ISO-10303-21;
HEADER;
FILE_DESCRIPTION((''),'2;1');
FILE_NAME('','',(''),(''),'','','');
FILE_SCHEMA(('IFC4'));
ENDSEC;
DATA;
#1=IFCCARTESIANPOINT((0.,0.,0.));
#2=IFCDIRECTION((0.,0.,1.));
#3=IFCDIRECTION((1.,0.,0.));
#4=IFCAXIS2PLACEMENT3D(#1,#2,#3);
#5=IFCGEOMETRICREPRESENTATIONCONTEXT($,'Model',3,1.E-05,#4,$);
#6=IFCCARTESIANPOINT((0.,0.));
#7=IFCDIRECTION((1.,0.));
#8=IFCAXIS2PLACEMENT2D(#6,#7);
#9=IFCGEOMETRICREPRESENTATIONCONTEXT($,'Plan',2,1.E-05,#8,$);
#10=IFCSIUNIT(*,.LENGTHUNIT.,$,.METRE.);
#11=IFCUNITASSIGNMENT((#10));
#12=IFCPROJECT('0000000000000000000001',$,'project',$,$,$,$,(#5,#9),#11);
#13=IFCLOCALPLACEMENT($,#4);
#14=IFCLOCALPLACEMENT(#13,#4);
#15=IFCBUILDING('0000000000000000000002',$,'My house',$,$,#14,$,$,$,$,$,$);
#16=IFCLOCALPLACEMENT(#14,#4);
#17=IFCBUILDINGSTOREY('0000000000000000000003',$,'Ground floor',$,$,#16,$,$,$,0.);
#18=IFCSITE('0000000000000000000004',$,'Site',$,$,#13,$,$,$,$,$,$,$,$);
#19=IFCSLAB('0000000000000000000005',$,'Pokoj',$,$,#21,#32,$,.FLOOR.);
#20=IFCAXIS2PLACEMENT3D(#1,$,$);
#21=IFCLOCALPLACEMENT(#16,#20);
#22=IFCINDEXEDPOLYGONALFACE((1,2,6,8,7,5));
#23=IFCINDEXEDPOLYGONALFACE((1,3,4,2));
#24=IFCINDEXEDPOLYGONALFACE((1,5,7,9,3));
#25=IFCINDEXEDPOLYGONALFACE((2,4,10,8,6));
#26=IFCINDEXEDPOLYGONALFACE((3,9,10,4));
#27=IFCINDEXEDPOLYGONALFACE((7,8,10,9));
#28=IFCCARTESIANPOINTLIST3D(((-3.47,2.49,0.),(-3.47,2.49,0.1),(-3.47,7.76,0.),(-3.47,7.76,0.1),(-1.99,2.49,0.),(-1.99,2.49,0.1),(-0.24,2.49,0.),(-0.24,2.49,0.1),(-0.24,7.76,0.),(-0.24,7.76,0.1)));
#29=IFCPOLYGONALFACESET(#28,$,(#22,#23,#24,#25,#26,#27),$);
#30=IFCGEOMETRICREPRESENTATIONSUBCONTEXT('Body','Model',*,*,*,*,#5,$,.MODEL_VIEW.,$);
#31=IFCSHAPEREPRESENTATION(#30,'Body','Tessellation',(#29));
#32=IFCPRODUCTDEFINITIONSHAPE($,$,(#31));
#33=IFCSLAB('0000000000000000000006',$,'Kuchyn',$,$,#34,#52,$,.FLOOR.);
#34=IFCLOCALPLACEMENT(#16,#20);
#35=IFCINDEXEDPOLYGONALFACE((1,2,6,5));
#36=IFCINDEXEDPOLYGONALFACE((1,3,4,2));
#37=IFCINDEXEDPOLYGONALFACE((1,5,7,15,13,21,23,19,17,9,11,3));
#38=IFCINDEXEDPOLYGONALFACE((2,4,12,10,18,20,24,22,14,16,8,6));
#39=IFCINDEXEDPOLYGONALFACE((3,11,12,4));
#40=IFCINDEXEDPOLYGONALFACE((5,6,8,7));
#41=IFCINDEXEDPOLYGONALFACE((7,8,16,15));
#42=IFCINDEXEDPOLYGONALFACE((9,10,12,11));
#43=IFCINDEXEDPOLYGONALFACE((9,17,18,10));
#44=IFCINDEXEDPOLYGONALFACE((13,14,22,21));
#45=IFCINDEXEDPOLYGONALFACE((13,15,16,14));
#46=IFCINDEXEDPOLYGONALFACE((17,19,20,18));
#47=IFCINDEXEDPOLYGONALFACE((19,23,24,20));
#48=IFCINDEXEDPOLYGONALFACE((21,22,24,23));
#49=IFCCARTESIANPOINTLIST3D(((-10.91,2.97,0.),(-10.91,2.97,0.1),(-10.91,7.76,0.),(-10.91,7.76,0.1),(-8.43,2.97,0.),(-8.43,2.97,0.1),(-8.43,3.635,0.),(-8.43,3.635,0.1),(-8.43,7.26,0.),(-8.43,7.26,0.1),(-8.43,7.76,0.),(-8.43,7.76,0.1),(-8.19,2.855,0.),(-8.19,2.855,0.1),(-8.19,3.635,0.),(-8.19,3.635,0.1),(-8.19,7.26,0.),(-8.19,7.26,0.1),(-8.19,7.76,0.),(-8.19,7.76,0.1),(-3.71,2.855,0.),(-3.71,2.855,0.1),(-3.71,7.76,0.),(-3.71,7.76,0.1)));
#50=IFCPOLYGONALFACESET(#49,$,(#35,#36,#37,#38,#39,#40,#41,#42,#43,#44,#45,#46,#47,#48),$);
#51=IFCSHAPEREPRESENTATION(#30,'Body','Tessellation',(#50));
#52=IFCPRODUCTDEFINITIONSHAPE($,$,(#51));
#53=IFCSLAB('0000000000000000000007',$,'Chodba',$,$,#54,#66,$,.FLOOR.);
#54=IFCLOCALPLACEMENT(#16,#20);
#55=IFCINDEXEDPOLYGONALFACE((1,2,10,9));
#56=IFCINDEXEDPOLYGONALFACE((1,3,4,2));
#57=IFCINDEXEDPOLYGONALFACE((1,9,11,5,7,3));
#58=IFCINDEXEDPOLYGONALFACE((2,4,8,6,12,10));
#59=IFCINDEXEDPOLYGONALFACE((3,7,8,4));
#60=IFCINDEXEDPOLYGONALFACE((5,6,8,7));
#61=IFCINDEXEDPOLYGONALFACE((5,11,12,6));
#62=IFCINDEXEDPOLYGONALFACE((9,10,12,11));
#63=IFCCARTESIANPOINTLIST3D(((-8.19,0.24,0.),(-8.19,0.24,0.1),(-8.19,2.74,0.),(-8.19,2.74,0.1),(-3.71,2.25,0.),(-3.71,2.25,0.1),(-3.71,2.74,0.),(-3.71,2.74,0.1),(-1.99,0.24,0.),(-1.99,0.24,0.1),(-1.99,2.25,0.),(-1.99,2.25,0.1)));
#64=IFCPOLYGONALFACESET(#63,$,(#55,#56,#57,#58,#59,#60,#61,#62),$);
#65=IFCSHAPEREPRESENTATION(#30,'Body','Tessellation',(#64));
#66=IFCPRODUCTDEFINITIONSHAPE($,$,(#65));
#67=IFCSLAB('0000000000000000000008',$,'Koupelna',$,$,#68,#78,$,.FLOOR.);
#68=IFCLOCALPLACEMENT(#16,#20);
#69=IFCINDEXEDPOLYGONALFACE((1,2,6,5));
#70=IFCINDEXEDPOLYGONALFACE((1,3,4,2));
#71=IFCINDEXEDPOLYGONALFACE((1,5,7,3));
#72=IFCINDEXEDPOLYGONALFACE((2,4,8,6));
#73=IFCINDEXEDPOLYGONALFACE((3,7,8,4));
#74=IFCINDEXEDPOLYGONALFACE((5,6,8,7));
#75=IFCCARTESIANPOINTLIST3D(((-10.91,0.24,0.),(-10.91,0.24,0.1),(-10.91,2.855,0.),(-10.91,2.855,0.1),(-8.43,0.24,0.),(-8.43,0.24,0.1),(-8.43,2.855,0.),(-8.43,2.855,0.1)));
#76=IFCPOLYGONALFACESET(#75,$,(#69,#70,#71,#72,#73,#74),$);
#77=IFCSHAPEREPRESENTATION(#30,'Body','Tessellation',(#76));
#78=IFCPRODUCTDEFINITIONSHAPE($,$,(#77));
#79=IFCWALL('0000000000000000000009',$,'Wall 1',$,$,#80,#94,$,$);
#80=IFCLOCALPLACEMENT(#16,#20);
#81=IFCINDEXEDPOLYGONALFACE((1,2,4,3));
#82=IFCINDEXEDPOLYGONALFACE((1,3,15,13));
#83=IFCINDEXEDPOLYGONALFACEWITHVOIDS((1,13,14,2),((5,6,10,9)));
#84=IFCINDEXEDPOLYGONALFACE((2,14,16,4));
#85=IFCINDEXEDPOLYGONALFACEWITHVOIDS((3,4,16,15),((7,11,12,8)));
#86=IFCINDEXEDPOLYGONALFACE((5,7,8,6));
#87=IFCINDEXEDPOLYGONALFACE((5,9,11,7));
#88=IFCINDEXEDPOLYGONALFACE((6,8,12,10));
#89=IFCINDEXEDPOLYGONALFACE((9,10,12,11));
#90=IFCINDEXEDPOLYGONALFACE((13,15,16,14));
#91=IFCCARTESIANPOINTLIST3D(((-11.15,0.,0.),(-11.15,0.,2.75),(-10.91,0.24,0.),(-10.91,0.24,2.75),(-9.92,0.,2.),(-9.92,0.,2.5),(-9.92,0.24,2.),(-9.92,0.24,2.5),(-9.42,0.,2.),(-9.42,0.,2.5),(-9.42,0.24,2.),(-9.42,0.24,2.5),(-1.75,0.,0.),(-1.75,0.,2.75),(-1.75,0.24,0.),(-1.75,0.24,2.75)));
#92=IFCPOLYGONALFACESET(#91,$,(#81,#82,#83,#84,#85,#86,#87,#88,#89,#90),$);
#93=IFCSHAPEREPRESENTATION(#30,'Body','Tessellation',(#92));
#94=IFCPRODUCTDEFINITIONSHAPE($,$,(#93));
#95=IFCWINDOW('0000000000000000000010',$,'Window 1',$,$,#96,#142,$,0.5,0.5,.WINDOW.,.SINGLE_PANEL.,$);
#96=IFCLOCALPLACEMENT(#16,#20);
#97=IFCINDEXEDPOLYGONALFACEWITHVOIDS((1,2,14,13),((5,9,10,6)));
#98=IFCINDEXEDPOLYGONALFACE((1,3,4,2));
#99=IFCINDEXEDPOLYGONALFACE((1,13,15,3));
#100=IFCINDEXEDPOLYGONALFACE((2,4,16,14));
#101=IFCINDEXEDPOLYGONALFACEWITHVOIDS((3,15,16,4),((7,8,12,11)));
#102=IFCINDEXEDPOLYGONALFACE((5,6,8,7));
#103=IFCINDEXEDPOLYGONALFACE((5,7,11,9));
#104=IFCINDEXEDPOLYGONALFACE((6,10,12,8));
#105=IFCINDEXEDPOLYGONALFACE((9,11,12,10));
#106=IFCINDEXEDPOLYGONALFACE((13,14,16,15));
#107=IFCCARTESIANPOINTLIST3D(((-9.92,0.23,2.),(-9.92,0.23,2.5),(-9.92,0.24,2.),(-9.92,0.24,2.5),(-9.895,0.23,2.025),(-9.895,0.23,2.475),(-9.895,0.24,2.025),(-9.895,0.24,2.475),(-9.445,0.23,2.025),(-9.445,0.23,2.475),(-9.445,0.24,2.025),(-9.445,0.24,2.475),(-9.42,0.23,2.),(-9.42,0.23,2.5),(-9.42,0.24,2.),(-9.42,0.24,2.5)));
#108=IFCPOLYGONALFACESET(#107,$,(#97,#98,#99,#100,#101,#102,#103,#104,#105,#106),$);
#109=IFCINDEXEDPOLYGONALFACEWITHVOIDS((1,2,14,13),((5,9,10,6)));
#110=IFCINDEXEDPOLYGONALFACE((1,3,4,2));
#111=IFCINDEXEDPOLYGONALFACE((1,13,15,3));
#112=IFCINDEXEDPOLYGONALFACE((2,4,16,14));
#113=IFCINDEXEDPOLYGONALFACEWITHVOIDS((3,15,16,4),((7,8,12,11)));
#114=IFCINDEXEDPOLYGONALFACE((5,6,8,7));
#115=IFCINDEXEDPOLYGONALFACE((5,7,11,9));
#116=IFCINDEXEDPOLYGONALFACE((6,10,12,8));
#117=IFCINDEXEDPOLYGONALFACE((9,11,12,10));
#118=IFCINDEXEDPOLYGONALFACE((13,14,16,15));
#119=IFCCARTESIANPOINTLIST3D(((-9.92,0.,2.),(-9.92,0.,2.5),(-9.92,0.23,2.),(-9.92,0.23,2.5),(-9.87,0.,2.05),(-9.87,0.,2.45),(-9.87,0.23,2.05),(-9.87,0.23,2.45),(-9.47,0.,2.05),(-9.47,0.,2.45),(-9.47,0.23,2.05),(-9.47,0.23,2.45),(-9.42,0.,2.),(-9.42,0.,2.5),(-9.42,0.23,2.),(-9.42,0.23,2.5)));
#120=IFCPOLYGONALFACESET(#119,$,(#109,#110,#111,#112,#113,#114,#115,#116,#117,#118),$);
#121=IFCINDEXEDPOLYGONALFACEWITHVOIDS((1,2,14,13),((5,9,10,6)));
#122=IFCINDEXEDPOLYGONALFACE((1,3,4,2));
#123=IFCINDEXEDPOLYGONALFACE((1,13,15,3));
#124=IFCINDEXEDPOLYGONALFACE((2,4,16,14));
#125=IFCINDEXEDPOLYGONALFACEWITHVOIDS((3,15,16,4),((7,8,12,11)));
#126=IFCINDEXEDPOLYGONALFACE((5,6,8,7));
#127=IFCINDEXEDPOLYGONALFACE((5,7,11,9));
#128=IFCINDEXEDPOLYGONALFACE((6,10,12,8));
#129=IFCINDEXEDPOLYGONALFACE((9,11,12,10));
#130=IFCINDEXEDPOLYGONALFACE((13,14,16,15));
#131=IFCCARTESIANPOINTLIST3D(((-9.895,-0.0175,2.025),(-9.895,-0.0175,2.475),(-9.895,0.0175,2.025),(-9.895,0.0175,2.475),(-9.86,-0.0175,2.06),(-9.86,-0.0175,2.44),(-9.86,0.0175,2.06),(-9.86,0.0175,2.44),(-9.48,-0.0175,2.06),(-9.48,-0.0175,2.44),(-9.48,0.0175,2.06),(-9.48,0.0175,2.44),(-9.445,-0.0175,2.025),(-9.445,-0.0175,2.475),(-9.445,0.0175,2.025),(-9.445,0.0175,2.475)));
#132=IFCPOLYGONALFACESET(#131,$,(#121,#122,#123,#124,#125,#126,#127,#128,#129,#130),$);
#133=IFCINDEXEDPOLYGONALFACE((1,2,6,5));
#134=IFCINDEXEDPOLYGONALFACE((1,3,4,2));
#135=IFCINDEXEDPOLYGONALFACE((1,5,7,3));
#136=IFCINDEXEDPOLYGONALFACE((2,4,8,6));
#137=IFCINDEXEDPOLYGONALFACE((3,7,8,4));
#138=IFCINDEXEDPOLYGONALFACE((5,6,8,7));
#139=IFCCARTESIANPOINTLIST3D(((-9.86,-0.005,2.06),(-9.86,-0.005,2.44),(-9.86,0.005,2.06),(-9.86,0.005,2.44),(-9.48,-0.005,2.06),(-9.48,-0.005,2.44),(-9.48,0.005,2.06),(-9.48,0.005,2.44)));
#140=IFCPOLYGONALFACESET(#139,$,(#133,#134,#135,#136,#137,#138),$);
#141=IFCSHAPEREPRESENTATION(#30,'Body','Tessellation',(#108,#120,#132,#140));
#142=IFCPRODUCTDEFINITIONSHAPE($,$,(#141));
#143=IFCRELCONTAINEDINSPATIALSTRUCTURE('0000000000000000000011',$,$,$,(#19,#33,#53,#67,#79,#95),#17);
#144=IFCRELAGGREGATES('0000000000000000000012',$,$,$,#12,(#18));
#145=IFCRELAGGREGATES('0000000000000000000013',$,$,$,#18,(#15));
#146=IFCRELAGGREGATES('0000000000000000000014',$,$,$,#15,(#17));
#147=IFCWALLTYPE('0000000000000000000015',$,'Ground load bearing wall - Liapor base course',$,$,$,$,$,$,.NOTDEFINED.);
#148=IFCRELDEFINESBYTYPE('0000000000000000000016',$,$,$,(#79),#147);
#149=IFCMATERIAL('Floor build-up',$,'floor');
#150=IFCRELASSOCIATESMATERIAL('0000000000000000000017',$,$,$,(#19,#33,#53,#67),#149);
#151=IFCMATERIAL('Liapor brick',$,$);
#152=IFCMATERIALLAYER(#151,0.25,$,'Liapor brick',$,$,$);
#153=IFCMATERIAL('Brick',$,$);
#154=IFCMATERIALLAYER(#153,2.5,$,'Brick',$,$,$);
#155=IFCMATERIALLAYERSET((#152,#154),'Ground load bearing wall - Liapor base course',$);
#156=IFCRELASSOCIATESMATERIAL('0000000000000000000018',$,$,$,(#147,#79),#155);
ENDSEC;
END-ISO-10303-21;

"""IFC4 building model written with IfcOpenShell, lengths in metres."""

from ifc_helpers import new_model, entity, si_unit, frame, origin_with_axes, origin_2d_with_axis, place, context, subcontext, project, spatial, line, indexed_curve, outline, extrude, shape, source, transform, mapped, material, layer, layer_set, layer_usage, type_object, element, fill, save


model = new_model("IFC4")

# Units and contexts
model_context = context("Model", 3, precision=1e-05, world=origin_with_axes())
plan_context = context("Plan", 2, precision=1e-05, world=origin_2d_with_axis())
body_context_1 = subcontext(model_context, "Body", "Model", "MODEL_VIEW")
body_context_2 = subcontext(plan_context, "Body", "Plan", "PLAN_VIEW")
ifc_project = project(units=[si_unit("LENGTHUNIT", "METRE")], contexts=[model_context, plan_context])

# Site, building, storey
site_placement = place(None, origin_with_axes())
site = spatial("IfcSite", under=ifc_project, at=site_placement, Name="Site")
building_placement = place(site_placement, origin_with_axes())
building = spatial("IfcBuilding", under=site, at=building_placement, Name="My house")
storey_placement = place(building_placement, origin_with_axes())
storey = spatial("IfcBuildingStorey", under=building, at=storey_placement, Name="Ground floor", Elevation=0.0)

# Slabs
ifc_material_1 = material(Name="Floor build-up", Category="floor")
shared_shape_1 = source(origin_with_axes(), body_context_1, "Body", "SweptSolid", [
    extrude(outline(indexed_curve([(0.24, 2.49), (1.99, 2.49), (3.47, 2.49), (3.47, 7.76), (0.24, 7.76)])), None, (0.0, 0.0, 1.0), 0.1),
])
slab_1_placement = place(storey_placement, origin_with_axes())
element("IfcSlab", 1, at=slab_1_placement, inside=storey, material=ifc_material_1, Name="Pokoj", PredefinedType="FLOOR", context=body_context_1, shape_type="MappedRepresentation", body=[
    mapped(shared_shape_1, transform((0.0, 0.0, 0.0), x_axis=(-1.0, 0.0, 0.0), y_axis=(0.0, 1.0, 0.0), z_axis=(0.0, 0.0, 1.0), scale=1.0)),
])
shared_shape_2 = source(origin_with_axes(), body_context_1, "Body", "SweptSolid", [
    extrude(outline(indexed_curve([(3.71, 2.855), (8.19, 2.855), (8.19, 3.635), (8.43, 3.635), (8.43, 2.97), (10.91, 2.97), (10.91, 7.76), (8.43, 7.76), (8.43, 7.26), (8.19, 7.26), (8.19, 7.76), (3.71, 7.76)])), None, (0.0, 0.0, 1.0), 0.1),
])
slab_2_placement = place(storey_placement, origin_with_axes())
element("IfcSlab", 2, at=slab_2_placement, inside=storey, material=ifc_material_1, Name="Kuchyn", PredefinedType="FLOOR", context=body_context_1, shape_type="MappedRepresentation", body=[
    mapped(shared_shape_2, transform((0.0, 0.0, 0.0), x_axis=(-1.0, 0.0, 0.0), y_axis=(0.0, 1.0, 0.0), z_axis=(0.0, 0.0, 1.0), scale=1.0)),
])
shared_shape_3 = source(origin_with_axes(), body_context_1, "Body", "SweptSolid", [
    extrude(outline(indexed_curve([(1.99, 0.24), (8.19, 0.24), (8.19, 2.74), (3.71, 2.74), (3.71, 2.25), (1.99, 2.25)])), None, (0.0, 0.0, 1.0), 0.1),
])
slab_3_placement = place(storey_placement, origin_with_axes())
element("IfcSlab", 3, at=slab_3_placement, inside=storey, material=ifc_material_1, Name="Chodba", PredefinedType="FLOOR", context=body_context_1, shape_type="MappedRepresentation", body=[
    mapped(shared_shape_3, transform((0.0, 0.0, 0.0), x_axis=(-1.0, 0.0, 0.0), y_axis=(0.0, 1.0, 0.0), z_axis=(0.0, 0.0, 1.0), scale=1.0)),
])
shared_shape_4 = source(origin_with_axes(), body_context_1, "Body", "SweptSolid", [
    extrude(outline(indexed_curve([(8.43, 0.24), (10.91, 0.24), (10.91, 2.855), (8.43, 2.855)])), None, (0.0, 0.0, 1.0), 0.1),
])
slab_4_placement = place(storey_placement, origin_with_axes())
element("IfcSlab", 4, at=slab_4_placement, inside=storey, material=ifc_material_1, Name="Koupelna", PredefinedType="FLOOR", context=body_context_1, shape_type="MappedRepresentation", body=[
    mapped(shared_shape_4, transform((0.0, 0.0, 0.0), x_axis=(-1.0, 0.0, 0.0), y_axis=(0.0, 1.0, 0.0), z_axis=(0.0, 0.0, 1.0), scale=1.0)),
])

# Wall, opening, window
ifc_material_2 = material(Name="Liapor brick")
ifc_layer_1 = layer(ifc_material_2, 0.25, Name="Liapor brick")
ifc_material_3 = material(Name="Brick")
ifc_layer_2 = layer(ifc_material_3, 2.5, Name="Brick")
ifc_layer_set_1 = layer_set([ifc_layer_1, ifc_layer_2], Name="Ground load bearing wall - Liapor base course")
ifc_layer_usage_1 = layer_usage(ifc_layer_set_1, "AXIS3", "POSITIVE", 0.0)
wall_type_1 = type_object("IfcWallType", Name="Ground load bearing wall - Liapor base course", PredefinedType="NOTDEFINED", material=ifc_layer_set_1)
shared_shape_5 = source(origin_with_axes(), body_context_1, "Body", "SweptSolid", [
    extrude(outline(indexed_curve([(0.0, 0.0), (0.0, 0.24), (9.16, 0.24), (9.4, 0.0)], segments=[line(1, 2, 3, 4, 1)])), origin_with_axes(), (0.0, 0.0, 1.0), 2.75),
])
wall_1_placement = place(storey_placement, frame((-1.75, 0.0, 0.0), z_axis=(0.0, 0.0, 1.0), x_axis=(1.0, 0.0, 0.0)))
wall_1 = element("IfcWall", 5, at=wall_1_placement, inside=storey, type_object=wall_type_1, material=ifc_layer_usage_1, Name="Wall 1", context=body_context_1, shape_type="MappedRepresentation", body=[
    mapped(shared_shape_5, transform((0.0, 0.0, 0.0), x_axis=(-1.0, 0.0, 0.0), y_axis=(0.0, 1.0, 0.0), z_axis=(0.0, 0.0, 1.0), scale=1.0)),
])
shared_shape_6 = source(origin_with_axes(), body_context_1, "Body", "SweptSolid", [
    extrude(outline(indexed_curve([(0.0, 0.0), (0.0, 0.34), (0.5, 0.34), (0.5, 0.0), (0.0, 0.0)], self_intersect=False)), frame((0.0, -0.05, 0.0), z_axis=(0.0, 0.0, 1.0), x_axis=(1.0, 0.0, 0.0)), (0.0, 0.0, 1.0), 0.5),
])
opening_1_placement = place(wall_1_placement, frame((-7.67, 0.0, 2.0), z_axis=(0.0, 0.0, 1.0), x_axis=(1.0, 0.0, 0.0)))
opening_1 = element("IfcOpeningElement", 6, at=opening_1_placement, cuts=wall_1, PredefinedType="OPENING", context=body_context_1, shape_type="MappedRepresentation", body=[
    mapped(shared_shape_6, transform((0.0, 0.0, 0.0), x_axis=(-1.0, 0.0, 0.0), y_axis=(0.0, 1.0, 0.0), z_axis=(0.0, 0.0, 1.0), scale=1.0)),
])
shared_shape_7 = source(origin_with_axes(), body_context_1, "Body", "SweptSolid", [
    extrude(outline(indexed_curve([(0.0, 0.0), (0.5, 0.0), (0.5, 0.5), (0.0, 0.5)], segments=[line(1, 2, 3, 4, 1)]), holes=[indexed_curve([(0.025, 0.025), (0.475, 0.025), (0.475, 0.475), (0.025, 0.475)], segments=[line(1, 2, 3, 4, 1)])]), frame((0.0, 0.23, 0.0), z_axis=(0.0, -1.0, 0.0), x_axis=(1.0, 0.0, 0.0)), (0.0, 0.0, -1.0), 0.01),
    extrude(outline(indexed_curve([(0.0, 0.0), (0.5, 0.0), (0.5, 0.5), (0.0, 0.5)], segments=[line(1, 2, 3, 4, 1)]), holes=[indexed_curve([(0.05, 0.05), (0.45, 0.05), (0.45, 0.45), (0.05, 0.45)], segments=[line(1, 2, 3, 4, 1)])]), frame((0.0, 0.0, 0.0), z_axis=(0.0, -1.0, 0.0), x_axis=(1.0, 0.0, 0.0)), (0.0, 0.0, -1.0), 0.23),
    extrude(outline(indexed_curve([(0.0, 0.0), (0.45, 0.0), (0.45, 0.45), (0.0, 0.45)], segments=[line(1, 2, 3, 4, 1)]), holes=[indexed_curve([(0.035, 0.035), (0.415, 0.035), (0.415, 0.415), (0.035, 0.415)], segments=[line(1, 2, 3, 4, 1)])]), frame((0.025, -0.0175, 0.025), z_axis=(0.0, -1.0, 0.0), x_axis=(1.0, 0.0, 0.0)), (0.0, 0.0, -1.0), 0.035),
    extrude(outline(indexed_curve([(0.035, 0.035), (0.415, 0.035), (0.415, 0.415), (0.035, 0.415)], segments=[line(1, 2, 3, 4, 1)])), frame((0.025, -0.005, 0.025), z_axis=(0.0, -1.0, 0.0), x_axis=(1.0, 0.0, 0.0)), (0.0, 0.0, -1.0), 0.01),
])
shared_shape_8 = source(origin_with_axes(), body_context_2, "Body", "Curve2D", [
    entity("IfcIndexedPolyCurve", entity("IfcCartesianPointList2D", [[0.05, 0.0], [0.45, 0.0]])),
    entity("IfcIndexedPolyCurve", entity("IfcCartesianPointList2D", [[0.0, 0.24], [0.025, 0.24], [0.025, 0.23], [0.05, 0.23], [0.05, 0.0], [0.0, 0.0]]), [entity("IfcLineIndex", [1, 2, 3, 4, 5, 6, 1])]),
    entity("IfcIndexedPolyCurve", entity("IfcCartesianPointList2D", [[0.5, 0.24], [0.475, 0.24], [0.475, 0.23], [0.45, 0.23], [0.45, 0.0], [0.5, 0.0]]), [entity("IfcLineIndex", [1, 2, 3, 4, 5, 6, 1])]),
    entity("IfcIndexedPolyCurve", entity("IfcCartesianPointList2D", [[0.025, -0.0175], [0.06, -0.0175], [0.06, 0.0175], [0.025, 0.0175]]), [entity("IfcLineIndex", [1, 2, 3, 4, 1])]),
    entity("IfcIndexedPolyCurve", entity("IfcCartesianPointList2D", [[0.475, -0.0175], [0.44, -0.0175], [0.44, 0.0175], [0.475, 0.0175]]), [entity("IfcLineIndex", [1, 2, 3, 4, 1])]),
    entity("IfcIndexedPolyCurve", entity("IfcCartesianPointList2D", [[0.06, -0.0175], [0.44, -0.0175]])),
    entity("IfcIndexedPolyCurve", entity("IfcCartesianPointList2D", [[0.06, 0.0175], [0.44, 0.0175]])),
    entity("IfcIndexedPolyCurve", entity("IfcCartesianPointList2D", [[0.06, 0.0], [0.44, 0.0]])),
])
window_1_placement = place(opening_1_placement, origin_with_axes())
window_1 = element("IfcWindow", 7, at=window_1_placement, inside=storey, Name="Window 1", OverallHeight=0.5, OverallWidth=0.5, PartitioningType="SINGLE_PANEL", PredefinedType="WINDOW", shapes=[
    shape(body_context_1, "Body", "MappedRepresentation", [mapped(shared_shape_7, transform((0.0, 0.0, 0.0), x_axis=(-1.0, 0.0, 0.0), y_axis=(0.0, 1.0, 0.0), z_axis=(0.0, 0.0, 1.0), scale=1.0))]),
    shape(body_context_2, "Body", "MappedRepresentation", [mapped(shared_shape_8, transform((0.0, 0.0, 0.0), x_axis=(-1.0, 0.0, 0.0), y_axis=(0.0, 1.0, 0.0), z_axis=(0.0, 0.0, 1.0), scale=1.0))]),
])
fill(opening_1, window_1)

save(model, "model.ifc")
